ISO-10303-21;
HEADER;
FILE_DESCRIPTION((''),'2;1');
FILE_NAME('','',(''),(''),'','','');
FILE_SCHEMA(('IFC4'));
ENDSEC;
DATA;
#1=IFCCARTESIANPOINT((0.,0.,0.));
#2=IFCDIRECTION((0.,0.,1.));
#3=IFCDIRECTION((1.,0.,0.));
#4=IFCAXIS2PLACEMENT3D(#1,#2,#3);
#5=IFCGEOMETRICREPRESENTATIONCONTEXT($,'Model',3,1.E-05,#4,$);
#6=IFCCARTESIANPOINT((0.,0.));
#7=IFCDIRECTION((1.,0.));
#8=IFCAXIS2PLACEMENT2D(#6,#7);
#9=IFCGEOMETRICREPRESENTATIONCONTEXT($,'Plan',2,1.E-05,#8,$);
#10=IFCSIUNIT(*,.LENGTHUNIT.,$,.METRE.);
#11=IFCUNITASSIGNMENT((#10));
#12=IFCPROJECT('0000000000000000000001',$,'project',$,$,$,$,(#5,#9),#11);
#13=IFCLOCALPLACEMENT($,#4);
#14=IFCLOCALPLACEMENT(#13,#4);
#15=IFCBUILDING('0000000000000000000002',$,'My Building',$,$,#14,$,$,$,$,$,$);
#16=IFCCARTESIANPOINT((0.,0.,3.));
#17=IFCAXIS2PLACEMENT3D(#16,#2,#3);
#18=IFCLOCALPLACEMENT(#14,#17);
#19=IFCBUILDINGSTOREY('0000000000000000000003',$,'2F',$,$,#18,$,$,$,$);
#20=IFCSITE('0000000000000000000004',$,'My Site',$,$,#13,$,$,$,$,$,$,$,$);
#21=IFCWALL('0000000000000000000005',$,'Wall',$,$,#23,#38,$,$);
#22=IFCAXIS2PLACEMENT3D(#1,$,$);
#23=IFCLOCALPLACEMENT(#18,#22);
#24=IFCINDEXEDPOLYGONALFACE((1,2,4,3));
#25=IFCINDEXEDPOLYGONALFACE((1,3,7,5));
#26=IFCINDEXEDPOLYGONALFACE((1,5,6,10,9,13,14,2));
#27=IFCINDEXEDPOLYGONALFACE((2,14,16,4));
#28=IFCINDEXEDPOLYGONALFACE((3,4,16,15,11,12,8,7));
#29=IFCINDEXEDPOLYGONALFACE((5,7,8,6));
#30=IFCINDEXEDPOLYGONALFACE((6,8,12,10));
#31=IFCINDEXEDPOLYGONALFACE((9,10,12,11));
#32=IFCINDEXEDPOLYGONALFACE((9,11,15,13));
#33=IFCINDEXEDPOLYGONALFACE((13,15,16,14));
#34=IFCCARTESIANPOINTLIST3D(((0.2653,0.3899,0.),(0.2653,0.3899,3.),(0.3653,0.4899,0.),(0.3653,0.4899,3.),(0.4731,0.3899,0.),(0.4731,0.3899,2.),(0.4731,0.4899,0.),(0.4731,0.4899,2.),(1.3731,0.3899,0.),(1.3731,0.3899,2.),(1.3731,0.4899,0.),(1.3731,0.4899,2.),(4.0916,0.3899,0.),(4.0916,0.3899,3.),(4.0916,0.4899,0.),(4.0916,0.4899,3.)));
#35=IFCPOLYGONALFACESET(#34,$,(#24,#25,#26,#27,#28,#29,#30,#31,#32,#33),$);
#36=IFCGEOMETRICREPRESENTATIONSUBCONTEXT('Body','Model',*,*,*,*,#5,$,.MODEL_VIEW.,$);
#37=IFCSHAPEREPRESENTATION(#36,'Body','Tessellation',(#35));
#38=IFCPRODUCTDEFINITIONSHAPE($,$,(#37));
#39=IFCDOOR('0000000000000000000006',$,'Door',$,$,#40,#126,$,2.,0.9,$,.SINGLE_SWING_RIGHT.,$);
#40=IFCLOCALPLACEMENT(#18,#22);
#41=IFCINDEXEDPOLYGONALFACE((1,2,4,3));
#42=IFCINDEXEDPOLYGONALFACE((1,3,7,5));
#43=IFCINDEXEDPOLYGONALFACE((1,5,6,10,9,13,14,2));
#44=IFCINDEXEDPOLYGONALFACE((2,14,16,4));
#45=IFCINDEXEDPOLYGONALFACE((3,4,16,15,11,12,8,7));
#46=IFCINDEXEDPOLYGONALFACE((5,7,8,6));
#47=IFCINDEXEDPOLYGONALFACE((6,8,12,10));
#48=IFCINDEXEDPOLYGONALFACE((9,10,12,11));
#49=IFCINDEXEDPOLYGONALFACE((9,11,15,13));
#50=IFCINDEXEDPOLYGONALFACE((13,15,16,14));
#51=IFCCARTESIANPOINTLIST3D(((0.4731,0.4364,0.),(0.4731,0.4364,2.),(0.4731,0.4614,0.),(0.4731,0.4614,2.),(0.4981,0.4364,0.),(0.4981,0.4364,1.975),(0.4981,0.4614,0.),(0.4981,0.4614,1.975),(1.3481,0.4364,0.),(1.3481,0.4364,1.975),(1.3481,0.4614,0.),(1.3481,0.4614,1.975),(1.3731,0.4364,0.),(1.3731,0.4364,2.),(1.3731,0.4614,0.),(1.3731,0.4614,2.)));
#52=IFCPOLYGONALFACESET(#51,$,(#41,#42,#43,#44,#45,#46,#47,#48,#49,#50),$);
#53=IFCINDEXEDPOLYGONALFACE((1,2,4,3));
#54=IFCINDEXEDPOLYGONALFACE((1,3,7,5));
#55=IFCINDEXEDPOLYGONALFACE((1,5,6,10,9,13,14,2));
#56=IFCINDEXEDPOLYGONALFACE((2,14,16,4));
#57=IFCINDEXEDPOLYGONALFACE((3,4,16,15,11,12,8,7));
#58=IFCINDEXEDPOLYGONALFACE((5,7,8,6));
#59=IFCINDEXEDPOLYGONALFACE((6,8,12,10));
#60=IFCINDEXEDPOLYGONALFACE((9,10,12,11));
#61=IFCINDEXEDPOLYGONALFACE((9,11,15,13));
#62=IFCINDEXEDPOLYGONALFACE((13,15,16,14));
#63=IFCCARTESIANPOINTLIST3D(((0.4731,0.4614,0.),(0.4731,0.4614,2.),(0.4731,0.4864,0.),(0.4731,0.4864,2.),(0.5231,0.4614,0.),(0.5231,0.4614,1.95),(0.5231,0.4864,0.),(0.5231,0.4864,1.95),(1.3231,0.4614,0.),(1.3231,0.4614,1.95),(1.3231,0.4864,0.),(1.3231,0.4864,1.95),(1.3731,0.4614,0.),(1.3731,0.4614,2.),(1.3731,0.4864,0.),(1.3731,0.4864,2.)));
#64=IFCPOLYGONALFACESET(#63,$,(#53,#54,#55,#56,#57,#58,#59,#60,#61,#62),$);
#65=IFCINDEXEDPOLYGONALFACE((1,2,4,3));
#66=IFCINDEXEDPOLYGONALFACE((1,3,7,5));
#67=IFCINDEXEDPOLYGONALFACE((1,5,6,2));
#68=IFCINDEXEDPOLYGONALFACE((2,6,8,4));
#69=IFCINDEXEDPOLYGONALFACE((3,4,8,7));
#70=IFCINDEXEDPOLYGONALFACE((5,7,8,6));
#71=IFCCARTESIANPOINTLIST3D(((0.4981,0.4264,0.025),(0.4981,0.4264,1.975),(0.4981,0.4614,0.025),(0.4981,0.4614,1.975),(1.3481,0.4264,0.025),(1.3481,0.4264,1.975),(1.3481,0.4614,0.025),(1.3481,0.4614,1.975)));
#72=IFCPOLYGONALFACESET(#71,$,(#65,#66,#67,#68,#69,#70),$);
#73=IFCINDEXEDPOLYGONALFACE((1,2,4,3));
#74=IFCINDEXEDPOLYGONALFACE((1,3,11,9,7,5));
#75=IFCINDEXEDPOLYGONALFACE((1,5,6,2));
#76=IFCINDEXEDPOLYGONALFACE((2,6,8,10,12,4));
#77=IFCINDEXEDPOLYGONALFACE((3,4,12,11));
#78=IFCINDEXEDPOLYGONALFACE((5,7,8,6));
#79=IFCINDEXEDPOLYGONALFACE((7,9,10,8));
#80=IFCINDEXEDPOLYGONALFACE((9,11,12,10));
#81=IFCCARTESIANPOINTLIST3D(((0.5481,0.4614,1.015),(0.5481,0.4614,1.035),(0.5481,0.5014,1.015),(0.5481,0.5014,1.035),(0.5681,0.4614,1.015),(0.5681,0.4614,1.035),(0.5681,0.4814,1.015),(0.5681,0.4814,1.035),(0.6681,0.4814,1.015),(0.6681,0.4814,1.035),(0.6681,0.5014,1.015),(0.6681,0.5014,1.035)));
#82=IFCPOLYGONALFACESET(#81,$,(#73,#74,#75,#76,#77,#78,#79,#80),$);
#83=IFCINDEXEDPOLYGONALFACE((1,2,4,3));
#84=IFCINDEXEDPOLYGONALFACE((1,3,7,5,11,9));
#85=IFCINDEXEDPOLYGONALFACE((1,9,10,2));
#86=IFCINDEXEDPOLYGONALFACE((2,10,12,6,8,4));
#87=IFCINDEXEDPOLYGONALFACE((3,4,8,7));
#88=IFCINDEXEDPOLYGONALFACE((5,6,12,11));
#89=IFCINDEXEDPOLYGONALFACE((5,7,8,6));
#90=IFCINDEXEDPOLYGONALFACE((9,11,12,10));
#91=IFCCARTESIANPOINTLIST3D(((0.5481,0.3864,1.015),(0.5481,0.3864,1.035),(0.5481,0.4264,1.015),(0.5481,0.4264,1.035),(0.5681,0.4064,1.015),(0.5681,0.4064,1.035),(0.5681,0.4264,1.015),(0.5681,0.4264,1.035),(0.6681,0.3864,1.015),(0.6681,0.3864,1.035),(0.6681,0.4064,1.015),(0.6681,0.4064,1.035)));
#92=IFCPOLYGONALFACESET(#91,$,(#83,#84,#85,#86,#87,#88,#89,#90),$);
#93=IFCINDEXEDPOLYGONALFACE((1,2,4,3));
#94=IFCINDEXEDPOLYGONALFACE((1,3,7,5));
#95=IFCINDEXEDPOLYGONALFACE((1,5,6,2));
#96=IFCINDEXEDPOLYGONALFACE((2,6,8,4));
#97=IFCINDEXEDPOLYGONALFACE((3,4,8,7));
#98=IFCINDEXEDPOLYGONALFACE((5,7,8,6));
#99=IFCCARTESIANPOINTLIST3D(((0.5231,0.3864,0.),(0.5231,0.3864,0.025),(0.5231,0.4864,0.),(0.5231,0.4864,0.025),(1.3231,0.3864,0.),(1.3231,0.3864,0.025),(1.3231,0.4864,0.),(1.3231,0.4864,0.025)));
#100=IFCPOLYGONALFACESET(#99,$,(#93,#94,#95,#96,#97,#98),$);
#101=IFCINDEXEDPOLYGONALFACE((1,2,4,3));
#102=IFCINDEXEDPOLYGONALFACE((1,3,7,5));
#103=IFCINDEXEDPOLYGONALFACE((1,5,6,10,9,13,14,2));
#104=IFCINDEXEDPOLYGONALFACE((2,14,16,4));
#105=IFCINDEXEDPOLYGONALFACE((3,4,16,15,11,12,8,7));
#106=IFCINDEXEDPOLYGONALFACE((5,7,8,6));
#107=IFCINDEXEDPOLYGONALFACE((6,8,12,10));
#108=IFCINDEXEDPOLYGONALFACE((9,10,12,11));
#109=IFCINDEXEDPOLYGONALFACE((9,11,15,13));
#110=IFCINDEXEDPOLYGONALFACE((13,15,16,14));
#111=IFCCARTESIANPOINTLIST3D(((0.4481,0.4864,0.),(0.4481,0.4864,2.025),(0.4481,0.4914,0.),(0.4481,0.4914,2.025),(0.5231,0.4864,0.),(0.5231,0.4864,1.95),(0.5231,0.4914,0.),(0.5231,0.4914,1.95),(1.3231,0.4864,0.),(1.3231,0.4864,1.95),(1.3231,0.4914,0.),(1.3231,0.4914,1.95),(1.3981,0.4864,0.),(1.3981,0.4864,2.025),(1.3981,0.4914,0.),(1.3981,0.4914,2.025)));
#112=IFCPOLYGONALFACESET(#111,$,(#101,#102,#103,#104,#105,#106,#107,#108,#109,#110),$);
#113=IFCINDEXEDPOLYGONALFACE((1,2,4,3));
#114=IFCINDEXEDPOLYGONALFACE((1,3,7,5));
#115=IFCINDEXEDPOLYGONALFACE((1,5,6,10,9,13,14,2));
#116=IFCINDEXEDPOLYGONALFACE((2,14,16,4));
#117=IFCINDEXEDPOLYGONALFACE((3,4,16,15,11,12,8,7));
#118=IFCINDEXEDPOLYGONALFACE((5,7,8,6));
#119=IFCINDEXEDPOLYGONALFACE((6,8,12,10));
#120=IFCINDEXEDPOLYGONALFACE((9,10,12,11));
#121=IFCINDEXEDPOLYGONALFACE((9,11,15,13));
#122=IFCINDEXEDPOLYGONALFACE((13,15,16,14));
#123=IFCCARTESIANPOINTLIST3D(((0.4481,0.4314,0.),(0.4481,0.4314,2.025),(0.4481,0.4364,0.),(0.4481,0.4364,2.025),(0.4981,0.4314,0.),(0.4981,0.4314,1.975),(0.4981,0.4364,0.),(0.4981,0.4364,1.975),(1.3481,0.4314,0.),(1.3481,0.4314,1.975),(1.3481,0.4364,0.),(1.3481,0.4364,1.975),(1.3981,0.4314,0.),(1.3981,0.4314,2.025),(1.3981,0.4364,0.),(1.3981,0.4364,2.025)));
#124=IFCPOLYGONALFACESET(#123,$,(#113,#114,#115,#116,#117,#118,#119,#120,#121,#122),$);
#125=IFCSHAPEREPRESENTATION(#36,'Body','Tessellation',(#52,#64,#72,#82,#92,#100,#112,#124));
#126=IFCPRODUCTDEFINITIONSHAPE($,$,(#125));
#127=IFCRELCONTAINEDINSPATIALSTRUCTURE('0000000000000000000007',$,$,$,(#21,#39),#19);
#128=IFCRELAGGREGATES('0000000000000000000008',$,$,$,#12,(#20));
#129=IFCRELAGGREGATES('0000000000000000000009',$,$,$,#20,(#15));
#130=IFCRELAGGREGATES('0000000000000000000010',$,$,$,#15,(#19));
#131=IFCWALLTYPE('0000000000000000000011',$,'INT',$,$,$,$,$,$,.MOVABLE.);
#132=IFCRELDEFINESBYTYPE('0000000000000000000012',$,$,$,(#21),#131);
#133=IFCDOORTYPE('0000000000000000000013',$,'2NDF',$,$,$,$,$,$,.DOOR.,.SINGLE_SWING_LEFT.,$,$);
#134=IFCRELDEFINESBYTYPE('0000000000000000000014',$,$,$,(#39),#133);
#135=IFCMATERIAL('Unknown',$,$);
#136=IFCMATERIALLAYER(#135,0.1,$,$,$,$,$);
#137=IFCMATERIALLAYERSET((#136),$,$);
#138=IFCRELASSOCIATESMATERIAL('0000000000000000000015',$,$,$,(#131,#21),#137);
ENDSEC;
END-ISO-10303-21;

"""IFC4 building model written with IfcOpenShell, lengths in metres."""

from ifc_helpers import new_model, entity, si_unit, frame, origin_with_axes, origin_2d_with_axis, place, context, subcontext, project, spatial, line, indexed_curve, outline, extrude, shape, source, transform, mapped, material, layer, layer_set, layer_usage, type_object, type_shapes, element, fill, save


model = new_model("IFC4")

# Units and contexts
model_context = context("Model", 3, precision=1e-05, world=origin_with_axes())
plan_context = context("Plan", 2, precision=1e-05, world=origin_2d_with_axis())
body_context_1 = subcontext(model_context, "Body", "Model", "MODEL_VIEW")
body_context_2 = subcontext(plan_context, "Body", "Plan", "PLAN_VIEW")
ifc_project = project(units=[si_unit("LENGTHUNIT", "METRE")], contexts=[model_context, plan_context])

# Site, building, storey
site_placement = place(None, origin_with_axes())
site = spatial("IfcSite", under=ifc_project, at=site_placement, Name="My Site")
building_placement = place(site_placement, origin_with_axes())
building = spatial("IfcBuilding", under=site, at=building_placement, Name="My Building")
storey_placement = place(building_placement, frame((0.0, 0.0, 3.0), z_axis=(0.0, 0.0, 1.0), x_axis=(1.0, 0.0, 0.0)))
storey = spatial("IfcBuildingStorey", under=building, at=storey_placement, Name="2F")

# Shared definitions
ifc_material = material(Name="Unknown")

# Shared definitions
door_type_1 = type_object("IfcDoorType", Name="2NDF", OperationType="SINGLE_SWING_LEFT", PredefinedType="DOOR")
shared_shape_1 = source(origin_with_axes(), body_context_1, "Body", "SweptSolid", [
    extrude(outline(indexed_curve([(0.0, 0.0), (0.0, 2.0), (0.9, 2.0), (0.9, 0.0), (0.875, 0.0), (0.875, 1.975), (0.025, 1.975), (0.025, 0.0)], segments=[line(1, 2, 3, 4, 5, 6, 7, 8, 1)])), frame((0.0, 0.025, 0.0), z_axis=(0.0, -1.0, 0.0), x_axis=(1.0, 0.0, 0.0)), (0.0, 0.0, -1.0), 0.025),
    extrude(outline(indexed_curve([(0.0, 0.0), (0.0, 2.0), (0.9, 2.0), (0.9, 0.0), (0.85, 0.0), (0.85, 1.95), (0.05, 1.95), (0.05, 0.0)], segments=[line(1, 2, 3, 4, 5, 6, 7, 8, 1)])), frame((0.0, 0.0, 0.0), z_axis=(0.0, -1.0, 0.0), x_axis=(1.0, 0.0, 0.0)), (0.0, 0.0, -1.0), 0.025),
    extrude(outline(indexed_curve([(0.0, 0.0), (0.85, 0.0), (0.85, 0.035), (0.0, 0.035)], segments=[line(1, 2, 3, 4, 1)])), frame((0.025, 0.025, 0.025), z_axis=(0.0, 0.0, 1.0), x_axis=(1.0, 0.0, 0.0)), (0.0, 0.0, 1.0), 1.95),
    extrude(outline(indexed_curve([(0.0, 0.0), (0.0, -0.04), (-0.12, -0.04), (-0.12, -0.02), (-0.02, -0.02), (-0.02, 0.0)], segments=[line(1, 2, 3, 4, 5, 6, 1)])), frame((0.825, 0.025, 1.015), z_axis=(0.0, 0.0, 1.0), x_axis=(1.0, 0.0, 0.0)), (0.0, 0.0, 1.0), 0.02),
    extrude(outline(indexed_curve([(0.0, 0.0), (0.0, 0.04), (-0.12, 0.04), (-0.12, 0.02), (-0.02, 0.02), (-0.02, 0.0)], segments=[line(1, 2, 3, 4, 5, 6, 1)])), frame((0.825, 0.06, 1.015), z_axis=(0.0, 0.0, 1.0), x_axis=(1.0, 0.0, 0.0)), (0.0, 0.0, 1.0), 0.02),
    extrude(outline(indexed_curve([(0.0, 0.0), (0.8, 0.0), (0.8, 0.1), (0.0, 0.1)], segments=[line(1, 2, 3, 4, 1)])), frame((0.05, 0.0, 0.0), z_axis=(0.0, 0.0, 1.0), x_axis=(1.0, 0.0, 0.0)), (0.0, 0.0, 1.0), 0.025),
    extrude(outline(indexed_curve([(0.0, 0.0), (0.0, 2.025), (0.95, 2.025), (0.95, 0.0), (0.875, 0.0), (0.875, 1.95), (0.075, 1.95), (0.075, 0.0)], segments=[line(1, 2, 3, 4, 5, 6, 7, 8, 1)])), frame((-0.025, -0.005, 0.0), z_axis=(0.0, -1.0, 0.0), x_axis=(1.0, 0.0, 0.0)), (0.0, 0.0, -1.0), 0.005),
    extrude(outline(indexed_curve([(0.0, 0.0), (0.0, 2.025), (0.95, 2.025), (0.95, 0.0), (0.9, 0.0), (0.9, 1.975), (0.05, 1.975), (0.05, 0.0)], segments=[line(1, 2, 3, 4, 5, 6, 7, 8, 1)])), frame((-0.025, 0.05, 0.0), z_axis=(0.0, -1.0, 0.0), x_axis=(1.0, 0.0, 0.0)), (0.0, 0.0, -1.0), 0.005),
])
shared_shape_2 = source(origin_with_axes(), body_context_2, "Body", "Curve2D", [
    entity("IfcIndexedPolyCurve", entity("IfcCartesianPointList2D", [[0.0, 0.0], [0.0, 0.05], [0.025, 0.05], [0.025, 0.025], [0.05, 0.025], [0.05, 0.0]]), [entity("IfcLineIndex", [1, 2, 3, 4, 5, 6, 1])]),
    entity("IfcIndexedPolyCurve", entity("IfcCartesianPointList2D", [[0.9, 0.0], [0.9, 0.05], [0.875, 0.05], [0.875, 0.025], [0.85, 0.025], [0.85, 0.0]]), [entity("IfcLineIndex", [1, 2, 3, 4, 5, 6, 1])]),
    entity("IfcTrimmedCurve", entity("IfcEllipse", entity("IfcAxis2Placement2D", entity("IfcCartesianPoint", [0.06, 0.05]), entity("IfcDirection", [1.0, 0.0])), 0.815, 0.85), [entity("IfcCartesianPoint", [0.875, 0.05])], [entity("IfcCartesianPoint", [0.06, 0.9])], True, "CARTESIAN"),
    entity("IfcIndexedPolyCurve", entity("IfcCartesianPointList2D", [[0.025, 0.05], [0.06, 0.05], [0.06, 0.9], [0.025, 0.9]]), [entity("IfcLineIndex", [1, 2, 3, 4, 1])]),
])
type_shapes(door_type_1, [shared_shape_1, shared_shape_2])

# Wall, opening, door
ifc_layer_1 = layer(ifc_material, 0.1)
ifc_layer_set_1 = layer_set([ifc_layer_1])
ifc_layer_usage_1 = layer_usage(ifc_layer_set_1, "AXIS2", "POSITIVE", -0.1)
wall_type_1 = type_object("IfcWallType", Name="INT", PredefinedType="MOVABLE", material=ifc_layer_set_1)
wall_1_placement = place(storey_placement, frame((0.3653, 0.4899, 0.0), z_axis=(0.0, 0.0, 1.0), x_axis=(1.0, 0.0, 0.0)))
wall_1 = element("IfcWall", 1, at=wall_1_placement, inside=storey, type_object=wall_type_1, material=ifc_layer_usage_1, Name="Wall", context=body_context_1, shape_type="SweptSolid", body=[
    extrude(outline(indexed_curve([(-0.1, -0.1), (0.0, 0.0), (3.7262, 0.0), (3.7262, -0.1)], segments=[line(1, 2, 3, 4, 1)])), origin_with_axes(), (0.0, 0.0, 1.0), 3.0),
])
placement_1 = place(storey_placement, frame((1.3731, 0.4864, 0.0), z_axis=(0.0, 0.0, 1.0), x_axis=(-1.0, 0.0, 0.0)))
opening_1 = element("IfcOpeningElement", 2, at=placement_1, cuts=wall_1, PredefinedType="OPENING", context=body_context_1, shape_type="SweptSolid", body=[
    extrude(outline(indexed_curve([(0.0, 0.0), (0.9, 0.0), (0.9, 2.0), (0.0, 2.0)], segments=[line(1, 2, 3, 4, 1)])), frame((0.0, -0.6, 0.0), z_axis=(0.0, -1.0, 0.0), x_axis=(1.0, 0.0, 0.0)), (0.0, 0.0, -1.0), 1.2),
])
door_1 = element("IfcDoor", 3, at=placement_1, inside=storey, type_object=door_type_1, Name="Door", OperationType="SINGLE_SWING_RIGHT", OverallHeight=2.0, OverallWidth=0.9, shapes=[
    shape(body_context_1, "Body", "MappedRepresentation", [mapped(shared_shape_1, transform((0.0, 0.0, 0.0), x_axis=(1.0, 0.0, 0.0), y_axis=(0.0, 1.0, 0.0), z_axis=(0.0, 0.0, 1.0), scale=1.0))]),
    shape(body_context_2, "Body", "MappedRepresentation", [mapped(shared_shape_2, transform((0.0, 0.0, 0.0), x_axis=(1.0, 0.0, 0.0), y_axis=(0.0, 1.0, 0.0), z_axis=(0.0, 0.0, 1.0), scale=1.0))]),
])
fill(opening_1, door_1)

save(model, "model.ifc")
